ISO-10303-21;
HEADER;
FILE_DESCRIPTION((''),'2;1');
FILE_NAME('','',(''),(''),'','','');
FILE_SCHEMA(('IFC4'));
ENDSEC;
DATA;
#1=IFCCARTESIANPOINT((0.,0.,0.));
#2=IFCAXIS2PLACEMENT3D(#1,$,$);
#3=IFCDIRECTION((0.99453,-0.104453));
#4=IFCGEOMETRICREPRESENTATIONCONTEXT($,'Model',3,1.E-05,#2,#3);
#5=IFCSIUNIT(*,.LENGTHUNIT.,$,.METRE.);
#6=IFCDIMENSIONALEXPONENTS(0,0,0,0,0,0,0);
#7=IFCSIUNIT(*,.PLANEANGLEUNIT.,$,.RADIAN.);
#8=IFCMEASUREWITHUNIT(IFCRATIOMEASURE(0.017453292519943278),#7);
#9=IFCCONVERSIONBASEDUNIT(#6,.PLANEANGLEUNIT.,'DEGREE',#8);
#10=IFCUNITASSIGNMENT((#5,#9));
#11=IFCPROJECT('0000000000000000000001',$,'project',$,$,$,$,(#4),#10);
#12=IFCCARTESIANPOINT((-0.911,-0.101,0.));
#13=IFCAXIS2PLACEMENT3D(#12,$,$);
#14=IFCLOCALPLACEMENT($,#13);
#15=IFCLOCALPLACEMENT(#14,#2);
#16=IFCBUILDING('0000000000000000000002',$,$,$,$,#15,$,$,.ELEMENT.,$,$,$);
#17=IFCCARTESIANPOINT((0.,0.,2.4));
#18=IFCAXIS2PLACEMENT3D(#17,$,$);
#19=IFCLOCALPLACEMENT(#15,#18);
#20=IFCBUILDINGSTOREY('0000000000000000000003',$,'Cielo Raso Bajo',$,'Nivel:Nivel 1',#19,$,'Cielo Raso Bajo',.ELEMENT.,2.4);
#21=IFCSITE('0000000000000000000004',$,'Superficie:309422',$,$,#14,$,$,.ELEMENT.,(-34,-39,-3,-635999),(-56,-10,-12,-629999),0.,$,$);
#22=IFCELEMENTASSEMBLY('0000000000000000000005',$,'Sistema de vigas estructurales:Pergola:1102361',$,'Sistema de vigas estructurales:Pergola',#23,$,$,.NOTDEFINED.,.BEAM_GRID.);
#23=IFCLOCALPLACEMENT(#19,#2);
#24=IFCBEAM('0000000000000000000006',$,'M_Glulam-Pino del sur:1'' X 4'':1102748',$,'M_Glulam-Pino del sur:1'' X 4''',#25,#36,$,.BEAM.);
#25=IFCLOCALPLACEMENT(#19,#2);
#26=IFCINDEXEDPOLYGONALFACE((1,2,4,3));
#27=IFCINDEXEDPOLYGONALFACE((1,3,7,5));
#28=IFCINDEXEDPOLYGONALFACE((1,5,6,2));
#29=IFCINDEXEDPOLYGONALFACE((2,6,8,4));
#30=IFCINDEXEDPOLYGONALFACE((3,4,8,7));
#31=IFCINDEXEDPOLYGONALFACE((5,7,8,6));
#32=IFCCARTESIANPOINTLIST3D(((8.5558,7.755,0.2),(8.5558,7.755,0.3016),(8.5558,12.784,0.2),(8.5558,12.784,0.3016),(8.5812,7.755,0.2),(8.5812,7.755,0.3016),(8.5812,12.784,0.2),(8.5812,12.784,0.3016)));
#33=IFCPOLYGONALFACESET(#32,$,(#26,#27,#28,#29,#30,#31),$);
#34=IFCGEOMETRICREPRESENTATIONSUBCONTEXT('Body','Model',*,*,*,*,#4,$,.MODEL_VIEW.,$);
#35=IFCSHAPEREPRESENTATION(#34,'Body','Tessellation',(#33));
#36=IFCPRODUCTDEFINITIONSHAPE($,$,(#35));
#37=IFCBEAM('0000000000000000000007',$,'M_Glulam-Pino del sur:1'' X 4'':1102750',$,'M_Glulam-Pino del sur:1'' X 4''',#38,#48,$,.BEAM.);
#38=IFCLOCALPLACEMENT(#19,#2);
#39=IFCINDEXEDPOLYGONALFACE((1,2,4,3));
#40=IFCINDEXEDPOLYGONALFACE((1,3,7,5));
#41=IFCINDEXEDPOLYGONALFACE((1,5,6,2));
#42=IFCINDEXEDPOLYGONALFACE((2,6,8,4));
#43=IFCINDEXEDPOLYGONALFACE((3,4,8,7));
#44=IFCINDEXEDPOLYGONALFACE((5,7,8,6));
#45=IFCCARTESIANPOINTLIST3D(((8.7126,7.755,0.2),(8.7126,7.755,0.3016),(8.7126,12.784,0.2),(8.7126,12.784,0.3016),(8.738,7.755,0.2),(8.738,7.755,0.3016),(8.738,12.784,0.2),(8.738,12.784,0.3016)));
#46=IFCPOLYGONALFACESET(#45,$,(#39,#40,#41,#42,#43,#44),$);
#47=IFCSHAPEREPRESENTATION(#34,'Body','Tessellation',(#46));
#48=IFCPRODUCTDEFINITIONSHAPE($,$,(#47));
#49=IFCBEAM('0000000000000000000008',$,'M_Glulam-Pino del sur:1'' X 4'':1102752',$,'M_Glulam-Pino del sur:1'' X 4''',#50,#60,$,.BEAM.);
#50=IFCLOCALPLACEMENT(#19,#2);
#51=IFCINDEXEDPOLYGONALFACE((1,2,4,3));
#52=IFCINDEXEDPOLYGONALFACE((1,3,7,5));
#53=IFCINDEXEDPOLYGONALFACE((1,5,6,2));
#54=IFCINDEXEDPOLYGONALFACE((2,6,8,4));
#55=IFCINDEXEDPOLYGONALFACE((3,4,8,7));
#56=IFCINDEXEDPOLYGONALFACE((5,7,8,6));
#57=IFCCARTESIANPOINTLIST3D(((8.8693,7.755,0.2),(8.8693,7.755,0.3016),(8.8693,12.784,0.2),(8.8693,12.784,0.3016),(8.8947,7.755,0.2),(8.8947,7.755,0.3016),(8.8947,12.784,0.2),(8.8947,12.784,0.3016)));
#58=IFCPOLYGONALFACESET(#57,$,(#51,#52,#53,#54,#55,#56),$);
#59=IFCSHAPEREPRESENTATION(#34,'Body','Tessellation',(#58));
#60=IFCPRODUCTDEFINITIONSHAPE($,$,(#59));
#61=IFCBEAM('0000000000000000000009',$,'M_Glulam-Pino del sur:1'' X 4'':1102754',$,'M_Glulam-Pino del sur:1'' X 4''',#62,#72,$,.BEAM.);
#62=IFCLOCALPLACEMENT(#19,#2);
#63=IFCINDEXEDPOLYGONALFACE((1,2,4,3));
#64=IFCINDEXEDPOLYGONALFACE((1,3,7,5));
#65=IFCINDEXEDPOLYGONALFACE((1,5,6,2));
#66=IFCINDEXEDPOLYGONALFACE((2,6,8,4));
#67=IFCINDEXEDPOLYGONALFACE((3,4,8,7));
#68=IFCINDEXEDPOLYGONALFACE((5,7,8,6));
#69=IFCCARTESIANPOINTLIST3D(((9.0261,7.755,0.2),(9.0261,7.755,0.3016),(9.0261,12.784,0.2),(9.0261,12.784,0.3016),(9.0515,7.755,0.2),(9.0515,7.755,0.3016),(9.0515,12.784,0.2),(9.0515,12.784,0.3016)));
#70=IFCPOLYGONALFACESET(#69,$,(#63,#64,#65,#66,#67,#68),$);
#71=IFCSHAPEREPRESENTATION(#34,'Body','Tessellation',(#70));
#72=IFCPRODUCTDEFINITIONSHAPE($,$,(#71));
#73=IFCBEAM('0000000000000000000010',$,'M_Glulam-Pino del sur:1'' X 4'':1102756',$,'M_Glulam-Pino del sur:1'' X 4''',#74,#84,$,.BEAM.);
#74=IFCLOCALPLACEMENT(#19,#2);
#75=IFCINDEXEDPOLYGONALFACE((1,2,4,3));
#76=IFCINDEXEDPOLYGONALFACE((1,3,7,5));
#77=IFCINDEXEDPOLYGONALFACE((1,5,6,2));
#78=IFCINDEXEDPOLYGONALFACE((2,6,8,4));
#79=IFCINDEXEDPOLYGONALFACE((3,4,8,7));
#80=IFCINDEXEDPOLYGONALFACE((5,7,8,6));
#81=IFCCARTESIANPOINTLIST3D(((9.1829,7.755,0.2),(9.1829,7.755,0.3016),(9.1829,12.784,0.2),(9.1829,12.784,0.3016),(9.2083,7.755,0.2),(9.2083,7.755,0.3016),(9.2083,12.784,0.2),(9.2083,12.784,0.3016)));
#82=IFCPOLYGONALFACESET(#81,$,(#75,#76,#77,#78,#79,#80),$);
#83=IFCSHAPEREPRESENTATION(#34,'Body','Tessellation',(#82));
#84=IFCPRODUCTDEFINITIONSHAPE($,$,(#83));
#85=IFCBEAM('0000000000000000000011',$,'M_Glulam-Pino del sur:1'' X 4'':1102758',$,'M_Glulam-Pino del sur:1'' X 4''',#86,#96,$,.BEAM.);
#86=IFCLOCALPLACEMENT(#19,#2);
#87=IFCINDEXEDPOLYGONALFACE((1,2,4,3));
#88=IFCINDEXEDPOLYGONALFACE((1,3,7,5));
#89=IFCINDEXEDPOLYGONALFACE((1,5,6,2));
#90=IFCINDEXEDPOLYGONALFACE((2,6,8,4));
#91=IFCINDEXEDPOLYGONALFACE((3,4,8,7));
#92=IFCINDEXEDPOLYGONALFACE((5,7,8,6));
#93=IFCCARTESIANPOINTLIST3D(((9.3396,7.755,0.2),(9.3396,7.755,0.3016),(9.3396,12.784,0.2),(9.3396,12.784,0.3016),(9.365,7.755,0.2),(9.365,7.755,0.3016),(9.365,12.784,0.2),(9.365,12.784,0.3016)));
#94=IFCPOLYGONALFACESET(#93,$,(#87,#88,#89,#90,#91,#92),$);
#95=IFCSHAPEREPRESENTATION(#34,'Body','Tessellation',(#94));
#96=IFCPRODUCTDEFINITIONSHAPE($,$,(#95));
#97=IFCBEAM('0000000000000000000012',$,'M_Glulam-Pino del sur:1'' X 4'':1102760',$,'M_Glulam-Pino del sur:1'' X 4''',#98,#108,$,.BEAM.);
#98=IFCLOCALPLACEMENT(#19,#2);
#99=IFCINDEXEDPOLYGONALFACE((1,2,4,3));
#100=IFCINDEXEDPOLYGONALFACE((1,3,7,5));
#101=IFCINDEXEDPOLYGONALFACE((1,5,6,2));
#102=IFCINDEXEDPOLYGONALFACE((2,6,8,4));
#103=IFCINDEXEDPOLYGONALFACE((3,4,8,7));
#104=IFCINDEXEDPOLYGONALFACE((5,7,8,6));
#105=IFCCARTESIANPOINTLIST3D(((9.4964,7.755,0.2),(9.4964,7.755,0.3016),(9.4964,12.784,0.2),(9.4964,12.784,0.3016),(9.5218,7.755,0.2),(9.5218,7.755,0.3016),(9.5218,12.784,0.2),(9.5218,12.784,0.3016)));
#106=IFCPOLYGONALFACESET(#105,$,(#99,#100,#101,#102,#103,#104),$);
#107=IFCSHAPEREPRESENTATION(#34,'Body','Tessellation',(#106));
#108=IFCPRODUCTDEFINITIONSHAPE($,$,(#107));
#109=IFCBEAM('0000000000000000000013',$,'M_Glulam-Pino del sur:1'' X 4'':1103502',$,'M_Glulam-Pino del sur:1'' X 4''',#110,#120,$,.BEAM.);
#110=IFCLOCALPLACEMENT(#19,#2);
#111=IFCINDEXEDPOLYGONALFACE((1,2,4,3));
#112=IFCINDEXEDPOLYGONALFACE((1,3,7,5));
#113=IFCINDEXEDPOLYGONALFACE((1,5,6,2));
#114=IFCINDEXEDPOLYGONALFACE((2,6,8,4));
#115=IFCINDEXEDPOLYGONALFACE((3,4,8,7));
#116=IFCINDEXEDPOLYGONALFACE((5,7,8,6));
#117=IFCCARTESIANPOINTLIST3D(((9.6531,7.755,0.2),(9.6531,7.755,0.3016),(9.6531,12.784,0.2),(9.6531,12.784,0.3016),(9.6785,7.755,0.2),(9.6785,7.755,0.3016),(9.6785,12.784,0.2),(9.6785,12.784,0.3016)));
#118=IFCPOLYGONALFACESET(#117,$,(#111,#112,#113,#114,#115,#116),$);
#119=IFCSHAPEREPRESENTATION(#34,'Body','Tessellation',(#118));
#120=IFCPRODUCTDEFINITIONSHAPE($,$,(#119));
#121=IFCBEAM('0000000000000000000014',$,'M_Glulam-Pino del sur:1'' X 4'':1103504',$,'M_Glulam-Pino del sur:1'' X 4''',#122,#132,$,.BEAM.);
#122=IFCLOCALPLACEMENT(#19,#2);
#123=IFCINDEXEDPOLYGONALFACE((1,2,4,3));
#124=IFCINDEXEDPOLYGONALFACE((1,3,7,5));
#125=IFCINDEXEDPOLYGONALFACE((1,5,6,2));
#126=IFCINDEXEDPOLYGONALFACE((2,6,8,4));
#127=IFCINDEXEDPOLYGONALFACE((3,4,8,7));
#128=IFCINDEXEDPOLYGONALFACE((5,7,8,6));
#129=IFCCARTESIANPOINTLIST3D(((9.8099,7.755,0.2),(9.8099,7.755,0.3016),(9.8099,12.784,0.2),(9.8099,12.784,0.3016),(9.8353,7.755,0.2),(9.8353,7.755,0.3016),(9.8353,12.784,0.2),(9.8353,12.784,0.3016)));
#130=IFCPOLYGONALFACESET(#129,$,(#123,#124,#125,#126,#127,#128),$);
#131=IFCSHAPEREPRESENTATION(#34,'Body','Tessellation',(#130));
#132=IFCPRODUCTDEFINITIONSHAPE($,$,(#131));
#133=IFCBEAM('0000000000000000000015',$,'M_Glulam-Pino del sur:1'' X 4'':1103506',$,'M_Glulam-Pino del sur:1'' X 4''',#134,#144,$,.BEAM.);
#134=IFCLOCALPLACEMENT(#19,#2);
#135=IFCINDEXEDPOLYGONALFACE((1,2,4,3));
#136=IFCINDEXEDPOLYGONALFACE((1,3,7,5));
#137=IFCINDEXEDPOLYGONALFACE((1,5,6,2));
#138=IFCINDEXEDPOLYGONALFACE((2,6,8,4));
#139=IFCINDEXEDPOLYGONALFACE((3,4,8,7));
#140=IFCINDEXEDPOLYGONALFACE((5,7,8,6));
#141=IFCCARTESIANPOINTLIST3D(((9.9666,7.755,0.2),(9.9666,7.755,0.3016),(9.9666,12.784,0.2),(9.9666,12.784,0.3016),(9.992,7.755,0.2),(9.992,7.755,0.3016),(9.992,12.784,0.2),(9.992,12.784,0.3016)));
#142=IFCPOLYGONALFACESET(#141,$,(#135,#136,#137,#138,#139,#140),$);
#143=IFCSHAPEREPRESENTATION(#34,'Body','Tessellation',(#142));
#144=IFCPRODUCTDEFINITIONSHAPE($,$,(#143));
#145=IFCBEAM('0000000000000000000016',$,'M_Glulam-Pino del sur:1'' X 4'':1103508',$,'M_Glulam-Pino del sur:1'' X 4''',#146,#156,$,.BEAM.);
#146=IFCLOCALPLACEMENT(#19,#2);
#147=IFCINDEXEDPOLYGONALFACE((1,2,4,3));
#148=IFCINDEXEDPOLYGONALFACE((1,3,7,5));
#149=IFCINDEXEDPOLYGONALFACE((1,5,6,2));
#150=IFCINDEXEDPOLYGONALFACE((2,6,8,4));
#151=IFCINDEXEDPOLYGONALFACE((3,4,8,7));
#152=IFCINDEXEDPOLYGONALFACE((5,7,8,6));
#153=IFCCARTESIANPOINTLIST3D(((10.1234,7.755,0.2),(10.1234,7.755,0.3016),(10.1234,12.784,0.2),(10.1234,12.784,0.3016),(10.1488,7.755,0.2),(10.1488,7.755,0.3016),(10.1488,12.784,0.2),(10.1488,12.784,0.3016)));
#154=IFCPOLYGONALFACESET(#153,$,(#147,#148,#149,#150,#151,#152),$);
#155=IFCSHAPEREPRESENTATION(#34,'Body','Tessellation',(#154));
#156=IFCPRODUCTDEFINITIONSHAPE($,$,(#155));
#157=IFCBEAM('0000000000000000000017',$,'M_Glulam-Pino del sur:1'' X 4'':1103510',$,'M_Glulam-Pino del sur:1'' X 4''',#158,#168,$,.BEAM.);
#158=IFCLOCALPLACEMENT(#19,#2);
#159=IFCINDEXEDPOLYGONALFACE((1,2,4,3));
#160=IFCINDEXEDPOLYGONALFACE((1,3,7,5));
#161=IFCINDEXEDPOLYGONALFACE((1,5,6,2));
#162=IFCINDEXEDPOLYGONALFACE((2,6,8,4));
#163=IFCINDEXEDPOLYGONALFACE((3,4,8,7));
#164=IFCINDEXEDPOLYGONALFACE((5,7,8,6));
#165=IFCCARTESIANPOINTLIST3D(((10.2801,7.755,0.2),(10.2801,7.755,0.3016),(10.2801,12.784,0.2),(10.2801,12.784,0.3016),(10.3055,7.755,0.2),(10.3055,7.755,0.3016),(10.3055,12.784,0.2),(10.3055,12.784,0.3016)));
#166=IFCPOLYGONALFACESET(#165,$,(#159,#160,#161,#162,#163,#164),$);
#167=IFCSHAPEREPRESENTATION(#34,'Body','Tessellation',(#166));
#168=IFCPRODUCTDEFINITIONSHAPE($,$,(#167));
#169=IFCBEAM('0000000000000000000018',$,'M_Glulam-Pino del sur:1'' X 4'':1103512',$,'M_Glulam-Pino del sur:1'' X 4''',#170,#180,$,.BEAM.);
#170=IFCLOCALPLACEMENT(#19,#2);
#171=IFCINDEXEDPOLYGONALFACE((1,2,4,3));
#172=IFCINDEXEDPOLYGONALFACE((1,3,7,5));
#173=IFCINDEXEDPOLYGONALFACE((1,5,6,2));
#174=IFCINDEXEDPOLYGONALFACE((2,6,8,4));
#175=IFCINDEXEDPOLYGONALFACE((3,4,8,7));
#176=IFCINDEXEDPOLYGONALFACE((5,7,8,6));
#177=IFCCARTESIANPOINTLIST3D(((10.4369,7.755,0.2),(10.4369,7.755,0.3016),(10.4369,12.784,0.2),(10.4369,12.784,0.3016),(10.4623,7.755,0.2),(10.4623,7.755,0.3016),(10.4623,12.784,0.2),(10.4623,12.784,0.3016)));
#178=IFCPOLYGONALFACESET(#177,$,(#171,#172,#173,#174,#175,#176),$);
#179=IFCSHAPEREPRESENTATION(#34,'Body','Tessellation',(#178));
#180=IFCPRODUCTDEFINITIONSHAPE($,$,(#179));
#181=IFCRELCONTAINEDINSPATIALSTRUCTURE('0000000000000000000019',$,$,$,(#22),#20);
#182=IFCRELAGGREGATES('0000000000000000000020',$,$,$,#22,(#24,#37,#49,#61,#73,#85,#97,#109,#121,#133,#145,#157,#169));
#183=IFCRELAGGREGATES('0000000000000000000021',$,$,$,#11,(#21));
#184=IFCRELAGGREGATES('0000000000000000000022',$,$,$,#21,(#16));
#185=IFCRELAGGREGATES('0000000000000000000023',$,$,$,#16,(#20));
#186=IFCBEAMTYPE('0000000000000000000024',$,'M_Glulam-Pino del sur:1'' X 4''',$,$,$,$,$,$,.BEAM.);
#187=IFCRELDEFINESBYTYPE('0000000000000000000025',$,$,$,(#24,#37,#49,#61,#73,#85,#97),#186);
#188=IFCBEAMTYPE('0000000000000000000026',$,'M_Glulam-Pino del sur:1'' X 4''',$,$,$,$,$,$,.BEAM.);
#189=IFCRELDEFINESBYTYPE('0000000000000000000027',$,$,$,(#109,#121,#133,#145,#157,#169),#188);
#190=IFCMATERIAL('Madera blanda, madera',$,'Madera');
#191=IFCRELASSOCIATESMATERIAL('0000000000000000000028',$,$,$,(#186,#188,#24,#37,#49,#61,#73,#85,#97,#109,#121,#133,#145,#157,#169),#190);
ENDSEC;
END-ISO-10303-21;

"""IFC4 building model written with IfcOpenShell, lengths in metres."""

from ifc_helpers import new_model, entity, si_unit, converted_unit, direction, frame, origin, origin_2d_with_axis, place, context, subcontext, project, spatial, polyline, segment, composite_curve, rectangle, outline, extrude, source, transform, mapped, material, material_profile, profile_set, profile_usage, type_object, type_shapes, element, aggregate, save


model = new_model("IFC4")

# Units and contexts
model_context = context("Model", 3, precision=1e-05, world=origin(), true_north=direction((0.99453, -0.104453)))
body_context = subcontext(model_context, "Body", "Model", "MODEL_VIEW")
ifc_project = project(units=[si_unit("LENGTHUNIT", "METRE"), converted_unit("PLANEANGLEUNIT", "DEGREE", entity("IfcRatioMeasure", 0.017453292519943278), si_unit("PLANEANGLEUNIT", "RADIAN"), dimensions=[0, 0, 0, 0, 0, 0, 0])], contexts=[model_context])

# Site, building, storey
site_placement = place(None, frame((-0.911, -0.101, 0.0)))
site = spatial("IfcSite", under=ifc_project, at=site_placement, Name="Superficie:309422", CompositionType="ELEMENT", RefLatitude=(-34, -39, -3, -635999), RefLongitude=(-56, -10, -12, -629999), RefElevation=0.0)
building_placement = place(site_placement, origin())
building = spatial("IfcBuilding", under=site, at=building_placement, CompositionType="ELEMENT")
storey_placement = place(building_placement, frame((0.0, 0.0, 2.4)))
storey = spatial("IfcBuildingStorey", under=building, at=storey_placement, Name="Cielo Raso Bajo", ObjectType="Nivel:Nivel 1", LongName="Cielo Raso Bajo", CompositionType="ELEMENT", Elevation=2.4)

# Element assembly, beams
assembly_placement = place(storey_placement, origin())
assembly = element("IfcElementAssembly", 1, at=assembly_placement, inside=storey, Name="Sistema de vigas estructurales:Pergola:1102361", ObjectType="Sistema de vigas estructurales:Pergola", AssemblyPlace="NOTDEFINED", PredefinedType="BEAM_GRID")
ifc_material_1 = material(Name="Madera blanda, madera", Category="Madera")
ifc_material_profile_1 = material_profile(ifc_material_1, outline(composite_curve([segment(polyline([(-0.0127, 0.0508, 0.0), (0.0127, 0.0508, 0.0)]), True, "CONTINUOUS"), segment(polyline([(0.0127, 0.0508, 0.0), (0.0127, -0.0508, 0.0)]), True, "CONTINUOUS"), segment(polyline([(0.0127, -0.0508, 0.0), (-0.0127, -0.0508, 0.0)]), True, "CONTINUOUS"), segment(polyline([(-0.0127, -0.0508, 0.0), (-0.0127, 0.0508, 0.0)]), True, "CONTINUOUS")], self_intersect=False), kind="CURVE"), Name="1' X 4'")
ifc_material_profile_2 = material_profile(ifc_material_1, outline(composite_curve([segment(polyline([(2.5145, -0.0127, -0.0508), (2.5145, -0.0127, 0.0508)]), True, "CONTINUOUS"), segment(polyline([(2.5145, -0.0127, 0.0508), (-2.5145, -0.0127, 0.0508)]), True, "CONTINUOUS"), segment(polyline([(-2.5145, -0.0127, 0.0508), (-2.5145, -0.0127, -0.0508)]), True, "CONTINUOUS"), segment(polyline([(-2.5145, -0.0127, -0.0508), (2.5145, -0.0127, -0.0508)]), True, "CONTINUOUS")], self_intersect=False), kind="CURVE"), Name="1' X 4'")
ifc_profile_set_1 = profile_set([ifc_material_profile_1, ifc_material_profile_2], Name="1' X 4'")
beam_type_1 = type_object("IfcBeamType", Name="M_Glulam-Pino del sur:1' X 4'", PredefinedType="BEAM", material=ifc_profile_set_1)
shared_shape_1 = source(origin(), body_context, "Body", "SweptSolid", [
    extrude(rectangle(XDim=0.1016, YDim=0.0254, at=origin_2d_with_axis()), frame((-2.4455, 0.0, 0.0), z_axis=(1.0, 0.0, 0.0), x_axis=(0.0, 0.0, -1.0)), (0.0, 0.0, 1.0), 5.029),
])
type_shapes(beam_type_1, [shared_shape_1])
ifc_profile_usage_1 = profile_usage(ifc_profile_set_1, cardinal=8)
beam_1_placement = place(assembly_placement, frame((8.5685, 10.2005, 0.2508), z_axis=(0.0, 0.0, 1.0), x_axis=(0.0, 1.0, 0.0)))
beam_1 = element("IfcBeam", 2, at=beam_1_placement, type_object=beam_type_1, material=ifc_profile_usage_1, Name="M_Glulam-Pino del sur:1' X 4':1102748", ObjectType="M_Glulam-Pino del sur:1' X 4'", PredefinedType="BEAM", context=body_context, shape_type="MappedRepresentation", body=[
    mapped(shared_shape_1, transform((0.0, 0.0, 0.0), scale=1.0)),
])
ifc_profile_usage_2 = profile_usage(ifc_profile_set_1, cardinal=8)
beam_2_placement = place(assembly_placement, frame((8.7253, 10.2005, 0.2508), z_axis=(0.0, 0.0, 1.0), x_axis=(0.0, 1.0, 0.0)))
beam_2 = element("IfcBeam", 3, at=beam_2_placement, type_object=beam_type_1, material=ifc_profile_usage_2, Name="M_Glulam-Pino del sur:1' X 4':1102750", ObjectType="M_Glulam-Pino del sur:1' X 4'", PredefinedType="BEAM", context=body_context, shape_type="MappedRepresentation", body=[
    mapped(shared_shape_1, transform((0.0, 0.0, 0.0), scale=1.0)),
])
ifc_profile_usage_3 = profile_usage(ifc_profile_set_1, cardinal=8)
beam_3_placement = place(assembly_placement, frame((8.882, 10.2005, 0.2508), z_axis=(0.0, 0.0, 1.0), x_axis=(0.0, 1.0, 0.0)))
beam_3 = element("IfcBeam", 4, at=beam_3_placement, type_object=beam_type_1, material=ifc_profile_usage_3, Name="M_Glulam-Pino del sur:1' X 4':1102752", ObjectType="M_Glulam-Pino del sur:1' X 4'", PredefinedType="BEAM", context=body_context, shape_type="MappedRepresentation", body=[
    mapped(shared_shape_1, transform((0.0, 0.0, 0.0), scale=1.0)),
])
ifc_profile_usage_4 = profile_usage(ifc_profile_set_1, cardinal=8)
beam_4_placement = place(assembly_placement, frame((9.0388, 10.2005, 0.2508), z_axis=(0.0, 0.0, 1.0), x_axis=(0.0, 1.0, 0.0)))
beam_4 = element("IfcBeam", 5, at=beam_4_placement, type_object=beam_type_1, material=ifc_profile_usage_4, Name="M_Glulam-Pino del sur:1' X 4':1102754", ObjectType="M_Glulam-Pino del sur:1' X 4'", PredefinedType="BEAM", context=body_context, shape_type="MappedRepresentation", body=[
    mapped(shared_shape_1, transform((0.0, 0.0, 0.0), scale=1.0)),
])
ifc_profile_usage_5 = profile_usage(ifc_profile_set_1, cardinal=8)
beam_5_placement = place(assembly_placement, frame((9.1956, 10.2005, 0.2508), z_axis=(0.0, 0.0, 1.0), x_axis=(0.0, 1.0, 0.0)))
beam_5 = element("IfcBeam", 6, at=beam_5_placement, type_object=beam_type_1, material=ifc_profile_usage_5, Name="M_Glulam-Pino del sur:1' X 4':1102756", ObjectType="M_Glulam-Pino del sur:1' X 4'", PredefinedType="BEAM", context=body_context, shape_type="MappedRepresentation", body=[
    mapped(shared_shape_1, transform((0.0, 0.0, 0.0), scale=1.0)),
])
ifc_profile_usage_6 = profile_usage(ifc_profile_set_1, cardinal=8)
beam_6_placement = place(assembly_placement, frame((9.3523, 10.2005, 0.2508), z_axis=(0.0, 0.0, 1.0), x_axis=(0.0, 1.0, 0.0)))
beam_6 = element("IfcBeam", 7, at=beam_6_placement, type_object=beam_type_1, material=ifc_profile_usage_6, Name="M_Glulam-Pino del sur:1' X 4':1102758", ObjectType="M_Glulam-Pino del sur:1' X 4'", PredefinedType="BEAM", context=body_context, shape_type="MappedRepresentation", body=[
    mapped(shared_shape_1, transform((0.0, 0.0, 0.0), scale=1.0)),
])
ifc_profile_usage_7 = profile_usage(ifc_profile_set_1, cardinal=8)
beam_7_placement = place(assembly_placement, frame((9.5091, 10.2005, 0.2508), z_axis=(0.0, 0.0, 1.0), x_axis=(0.0, 1.0, 0.0)))
beam_7 = element("IfcBeam", 8, at=beam_7_placement, type_object=beam_type_1, material=ifc_profile_usage_7, Name="M_Glulam-Pino del sur:1' X 4':1102760", ObjectType="M_Glulam-Pino del sur:1' X 4'", PredefinedType="BEAM", context=body_context, shape_type="MappedRepresentation", body=[
    mapped(shared_shape_1, transform((0.0, 0.0, 0.0), scale=1.0)),
])
ifc_profile_usage_8 = profile_usage(ifc_profile_set_1, cardinal=8)
beam_type_2 = type_object("IfcBeamType", Name="M_Glulam-Pino del sur:1' X 4'", PredefinedType="BEAM", material=ifc_profile_set_1)
shared_shape_2 = source(origin(), body_context, "Body", "SweptSolid", [
    extrude(rectangle(XDim=0.1016, YDim=0.0254, at=origin_2d_with_axis()), frame((-2.4455, 0.0, 0.0), z_axis=(1.0, 0.0, 0.0), x_axis=(0.0, 0.0, -1.0)), (0.0, 0.0, 1.0), 5.029),
])
type_shapes(beam_type_2, [shared_shape_2])
beam_8_placement = place(assembly_placement, frame((9.6658, 10.2005, 0.2508), z_axis=(0.0, 0.0, 1.0), x_axis=(0.0, 1.0, 0.0)))
beam_8 = element("IfcBeam", 9, at=beam_8_placement, type_object=beam_type_2, material=ifc_profile_usage_8, Name="M_Glulam-Pino del sur:1' X 4':1103502", ObjectType="M_Glulam-Pino del sur:1' X 4'", PredefinedType="BEAM", context=body_context, shape_type="MappedRepresentation", body=[
    mapped(shared_shape_2, transform((0.0, 0.0, 0.0), scale=1.0)),
])
ifc_profile_usage_9 = profile_usage(ifc_profile_set_1, cardinal=8)
beam_9_placement = place(assembly_placement, frame((9.8226, 10.2005, 0.2508), z_axis=(0.0, 0.0, 1.0), x_axis=(0.0, 1.0, 0.0)))
beam_9 = element("IfcBeam", 10, at=beam_9_placement, type_object=beam_type_2, material=ifc_profile_usage_9, Name="M_Glulam-Pino del sur:1' X 4':1103504", ObjectType="M_Glulam-Pino del sur:1' X 4'", PredefinedType="BEAM", context=body_context, shape_type="MappedRepresentation", body=[
    mapped(shared_shape_2, transform((0.0, 0.0, 0.0), scale=1.0)),
])
ifc_profile_usage_10 = profile_usage(ifc_profile_set_1, cardinal=8)
beam_10_placement = place(assembly_placement, frame((9.9793, 10.2005, 0.2508), z_axis=(0.0, 0.0, 1.0), x_axis=(0.0, 1.0, 0.0)))
beam_10 = element("IfcBeam", 11, at=beam_10_placement, type_object=beam_type_2, material=ifc_profile_usage_10, Name="M_Glulam-Pino del sur:1' X 4':1103506", ObjectType="M_Glulam-Pino del sur:1' X 4'", PredefinedType="BEAM", context=body_context, shape_type="MappedRepresentation", body=[
    mapped(shared_shape_2, transform((0.0, 0.0, 0.0), scale=1.0)),
])
ifc_profile_usage_11 = profile_usage(ifc_profile_set_1, cardinal=8)
beam_11_placement = place(assembly_placement, frame((10.1361, 10.2005, 0.2508), z_axis=(0.0, 0.0, 1.0), x_axis=(0.0, 1.0, 0.0)))
beam_11 = element("IfcBeam", 12, at=beam_11_placement, type_object=beam_type_2, material=ifc_profile_usage_11, Name="M_Glulam-Pino del sur:1' X 4':1103508", ObjectType="M_Glulam-Pino del sur:1' X 4'", PredefinedType="BEAM", context=body_context, shape_type="MappedRepresentation", body=[
    mapped(shared_shape_2, transform((0.0, 0.0, 0.0), scale=1.0)),
])
ifc_profile_usage_12 = profile_usage(ifc_profile_set_1, cardinal=8)
beam_12_placement = place(assembly_placement, frame((10.2928, 10.2005, 0.2508), z_axis=(0.0, 0.0, 1.0), x_axis=(0.0, 1.0, 0.0)))
beam_12 = element("IfcBeam", 13, at=beam_12_placement, type_object=beam_type_2, material=ifc_profile_usage_12, Name="M_Glulam-Pino del sur:1' X 4':1103510", ObjectType="M_Glulam-Pino del sur:1' X 4'", PredefinedType="BEAM", context=body_context, shape_type="MappedRepresentation", body=[
    mapped(shared_shape_2, transform((0.0, 0.0, 0.0), scale=1.0)),
])
ifc_profile_usage_13 = profile_usage(ifc_profile_set_1, cardinal=8)
beam_13_placement = place(assembly_placement, frame((10.4496, 10.2005, 0.2508), z_axis=(0.0, 0.0, 1.0), x_axis=(0.0, 1.0, 0.0)))
beam_13 = element("IfcBeam", 14, at=beam_13_placement, type_object=beam_type_2, material=ifc_profile_usage_13, Name="M_Glulam-Pino del sur:1' X 4':1103512", ObjectType="M_Glulam-Pino del sur:1' X 4'", PredefinedType="BEAM", context=body_context, shape_type="MappedRepresentation", body=[
    mapped(shared_shape_2, transform((0.0, 0.0, 0.0), scale=1.0)),
])
aggregate(assembly, [beam_1, beam_2, beam_3, beam_4, beam_5, beam_6, beam_7, beam_8, beam_9, beam_10, beam_11, beam_12, beam_13])

save(model, "model.ifc")
